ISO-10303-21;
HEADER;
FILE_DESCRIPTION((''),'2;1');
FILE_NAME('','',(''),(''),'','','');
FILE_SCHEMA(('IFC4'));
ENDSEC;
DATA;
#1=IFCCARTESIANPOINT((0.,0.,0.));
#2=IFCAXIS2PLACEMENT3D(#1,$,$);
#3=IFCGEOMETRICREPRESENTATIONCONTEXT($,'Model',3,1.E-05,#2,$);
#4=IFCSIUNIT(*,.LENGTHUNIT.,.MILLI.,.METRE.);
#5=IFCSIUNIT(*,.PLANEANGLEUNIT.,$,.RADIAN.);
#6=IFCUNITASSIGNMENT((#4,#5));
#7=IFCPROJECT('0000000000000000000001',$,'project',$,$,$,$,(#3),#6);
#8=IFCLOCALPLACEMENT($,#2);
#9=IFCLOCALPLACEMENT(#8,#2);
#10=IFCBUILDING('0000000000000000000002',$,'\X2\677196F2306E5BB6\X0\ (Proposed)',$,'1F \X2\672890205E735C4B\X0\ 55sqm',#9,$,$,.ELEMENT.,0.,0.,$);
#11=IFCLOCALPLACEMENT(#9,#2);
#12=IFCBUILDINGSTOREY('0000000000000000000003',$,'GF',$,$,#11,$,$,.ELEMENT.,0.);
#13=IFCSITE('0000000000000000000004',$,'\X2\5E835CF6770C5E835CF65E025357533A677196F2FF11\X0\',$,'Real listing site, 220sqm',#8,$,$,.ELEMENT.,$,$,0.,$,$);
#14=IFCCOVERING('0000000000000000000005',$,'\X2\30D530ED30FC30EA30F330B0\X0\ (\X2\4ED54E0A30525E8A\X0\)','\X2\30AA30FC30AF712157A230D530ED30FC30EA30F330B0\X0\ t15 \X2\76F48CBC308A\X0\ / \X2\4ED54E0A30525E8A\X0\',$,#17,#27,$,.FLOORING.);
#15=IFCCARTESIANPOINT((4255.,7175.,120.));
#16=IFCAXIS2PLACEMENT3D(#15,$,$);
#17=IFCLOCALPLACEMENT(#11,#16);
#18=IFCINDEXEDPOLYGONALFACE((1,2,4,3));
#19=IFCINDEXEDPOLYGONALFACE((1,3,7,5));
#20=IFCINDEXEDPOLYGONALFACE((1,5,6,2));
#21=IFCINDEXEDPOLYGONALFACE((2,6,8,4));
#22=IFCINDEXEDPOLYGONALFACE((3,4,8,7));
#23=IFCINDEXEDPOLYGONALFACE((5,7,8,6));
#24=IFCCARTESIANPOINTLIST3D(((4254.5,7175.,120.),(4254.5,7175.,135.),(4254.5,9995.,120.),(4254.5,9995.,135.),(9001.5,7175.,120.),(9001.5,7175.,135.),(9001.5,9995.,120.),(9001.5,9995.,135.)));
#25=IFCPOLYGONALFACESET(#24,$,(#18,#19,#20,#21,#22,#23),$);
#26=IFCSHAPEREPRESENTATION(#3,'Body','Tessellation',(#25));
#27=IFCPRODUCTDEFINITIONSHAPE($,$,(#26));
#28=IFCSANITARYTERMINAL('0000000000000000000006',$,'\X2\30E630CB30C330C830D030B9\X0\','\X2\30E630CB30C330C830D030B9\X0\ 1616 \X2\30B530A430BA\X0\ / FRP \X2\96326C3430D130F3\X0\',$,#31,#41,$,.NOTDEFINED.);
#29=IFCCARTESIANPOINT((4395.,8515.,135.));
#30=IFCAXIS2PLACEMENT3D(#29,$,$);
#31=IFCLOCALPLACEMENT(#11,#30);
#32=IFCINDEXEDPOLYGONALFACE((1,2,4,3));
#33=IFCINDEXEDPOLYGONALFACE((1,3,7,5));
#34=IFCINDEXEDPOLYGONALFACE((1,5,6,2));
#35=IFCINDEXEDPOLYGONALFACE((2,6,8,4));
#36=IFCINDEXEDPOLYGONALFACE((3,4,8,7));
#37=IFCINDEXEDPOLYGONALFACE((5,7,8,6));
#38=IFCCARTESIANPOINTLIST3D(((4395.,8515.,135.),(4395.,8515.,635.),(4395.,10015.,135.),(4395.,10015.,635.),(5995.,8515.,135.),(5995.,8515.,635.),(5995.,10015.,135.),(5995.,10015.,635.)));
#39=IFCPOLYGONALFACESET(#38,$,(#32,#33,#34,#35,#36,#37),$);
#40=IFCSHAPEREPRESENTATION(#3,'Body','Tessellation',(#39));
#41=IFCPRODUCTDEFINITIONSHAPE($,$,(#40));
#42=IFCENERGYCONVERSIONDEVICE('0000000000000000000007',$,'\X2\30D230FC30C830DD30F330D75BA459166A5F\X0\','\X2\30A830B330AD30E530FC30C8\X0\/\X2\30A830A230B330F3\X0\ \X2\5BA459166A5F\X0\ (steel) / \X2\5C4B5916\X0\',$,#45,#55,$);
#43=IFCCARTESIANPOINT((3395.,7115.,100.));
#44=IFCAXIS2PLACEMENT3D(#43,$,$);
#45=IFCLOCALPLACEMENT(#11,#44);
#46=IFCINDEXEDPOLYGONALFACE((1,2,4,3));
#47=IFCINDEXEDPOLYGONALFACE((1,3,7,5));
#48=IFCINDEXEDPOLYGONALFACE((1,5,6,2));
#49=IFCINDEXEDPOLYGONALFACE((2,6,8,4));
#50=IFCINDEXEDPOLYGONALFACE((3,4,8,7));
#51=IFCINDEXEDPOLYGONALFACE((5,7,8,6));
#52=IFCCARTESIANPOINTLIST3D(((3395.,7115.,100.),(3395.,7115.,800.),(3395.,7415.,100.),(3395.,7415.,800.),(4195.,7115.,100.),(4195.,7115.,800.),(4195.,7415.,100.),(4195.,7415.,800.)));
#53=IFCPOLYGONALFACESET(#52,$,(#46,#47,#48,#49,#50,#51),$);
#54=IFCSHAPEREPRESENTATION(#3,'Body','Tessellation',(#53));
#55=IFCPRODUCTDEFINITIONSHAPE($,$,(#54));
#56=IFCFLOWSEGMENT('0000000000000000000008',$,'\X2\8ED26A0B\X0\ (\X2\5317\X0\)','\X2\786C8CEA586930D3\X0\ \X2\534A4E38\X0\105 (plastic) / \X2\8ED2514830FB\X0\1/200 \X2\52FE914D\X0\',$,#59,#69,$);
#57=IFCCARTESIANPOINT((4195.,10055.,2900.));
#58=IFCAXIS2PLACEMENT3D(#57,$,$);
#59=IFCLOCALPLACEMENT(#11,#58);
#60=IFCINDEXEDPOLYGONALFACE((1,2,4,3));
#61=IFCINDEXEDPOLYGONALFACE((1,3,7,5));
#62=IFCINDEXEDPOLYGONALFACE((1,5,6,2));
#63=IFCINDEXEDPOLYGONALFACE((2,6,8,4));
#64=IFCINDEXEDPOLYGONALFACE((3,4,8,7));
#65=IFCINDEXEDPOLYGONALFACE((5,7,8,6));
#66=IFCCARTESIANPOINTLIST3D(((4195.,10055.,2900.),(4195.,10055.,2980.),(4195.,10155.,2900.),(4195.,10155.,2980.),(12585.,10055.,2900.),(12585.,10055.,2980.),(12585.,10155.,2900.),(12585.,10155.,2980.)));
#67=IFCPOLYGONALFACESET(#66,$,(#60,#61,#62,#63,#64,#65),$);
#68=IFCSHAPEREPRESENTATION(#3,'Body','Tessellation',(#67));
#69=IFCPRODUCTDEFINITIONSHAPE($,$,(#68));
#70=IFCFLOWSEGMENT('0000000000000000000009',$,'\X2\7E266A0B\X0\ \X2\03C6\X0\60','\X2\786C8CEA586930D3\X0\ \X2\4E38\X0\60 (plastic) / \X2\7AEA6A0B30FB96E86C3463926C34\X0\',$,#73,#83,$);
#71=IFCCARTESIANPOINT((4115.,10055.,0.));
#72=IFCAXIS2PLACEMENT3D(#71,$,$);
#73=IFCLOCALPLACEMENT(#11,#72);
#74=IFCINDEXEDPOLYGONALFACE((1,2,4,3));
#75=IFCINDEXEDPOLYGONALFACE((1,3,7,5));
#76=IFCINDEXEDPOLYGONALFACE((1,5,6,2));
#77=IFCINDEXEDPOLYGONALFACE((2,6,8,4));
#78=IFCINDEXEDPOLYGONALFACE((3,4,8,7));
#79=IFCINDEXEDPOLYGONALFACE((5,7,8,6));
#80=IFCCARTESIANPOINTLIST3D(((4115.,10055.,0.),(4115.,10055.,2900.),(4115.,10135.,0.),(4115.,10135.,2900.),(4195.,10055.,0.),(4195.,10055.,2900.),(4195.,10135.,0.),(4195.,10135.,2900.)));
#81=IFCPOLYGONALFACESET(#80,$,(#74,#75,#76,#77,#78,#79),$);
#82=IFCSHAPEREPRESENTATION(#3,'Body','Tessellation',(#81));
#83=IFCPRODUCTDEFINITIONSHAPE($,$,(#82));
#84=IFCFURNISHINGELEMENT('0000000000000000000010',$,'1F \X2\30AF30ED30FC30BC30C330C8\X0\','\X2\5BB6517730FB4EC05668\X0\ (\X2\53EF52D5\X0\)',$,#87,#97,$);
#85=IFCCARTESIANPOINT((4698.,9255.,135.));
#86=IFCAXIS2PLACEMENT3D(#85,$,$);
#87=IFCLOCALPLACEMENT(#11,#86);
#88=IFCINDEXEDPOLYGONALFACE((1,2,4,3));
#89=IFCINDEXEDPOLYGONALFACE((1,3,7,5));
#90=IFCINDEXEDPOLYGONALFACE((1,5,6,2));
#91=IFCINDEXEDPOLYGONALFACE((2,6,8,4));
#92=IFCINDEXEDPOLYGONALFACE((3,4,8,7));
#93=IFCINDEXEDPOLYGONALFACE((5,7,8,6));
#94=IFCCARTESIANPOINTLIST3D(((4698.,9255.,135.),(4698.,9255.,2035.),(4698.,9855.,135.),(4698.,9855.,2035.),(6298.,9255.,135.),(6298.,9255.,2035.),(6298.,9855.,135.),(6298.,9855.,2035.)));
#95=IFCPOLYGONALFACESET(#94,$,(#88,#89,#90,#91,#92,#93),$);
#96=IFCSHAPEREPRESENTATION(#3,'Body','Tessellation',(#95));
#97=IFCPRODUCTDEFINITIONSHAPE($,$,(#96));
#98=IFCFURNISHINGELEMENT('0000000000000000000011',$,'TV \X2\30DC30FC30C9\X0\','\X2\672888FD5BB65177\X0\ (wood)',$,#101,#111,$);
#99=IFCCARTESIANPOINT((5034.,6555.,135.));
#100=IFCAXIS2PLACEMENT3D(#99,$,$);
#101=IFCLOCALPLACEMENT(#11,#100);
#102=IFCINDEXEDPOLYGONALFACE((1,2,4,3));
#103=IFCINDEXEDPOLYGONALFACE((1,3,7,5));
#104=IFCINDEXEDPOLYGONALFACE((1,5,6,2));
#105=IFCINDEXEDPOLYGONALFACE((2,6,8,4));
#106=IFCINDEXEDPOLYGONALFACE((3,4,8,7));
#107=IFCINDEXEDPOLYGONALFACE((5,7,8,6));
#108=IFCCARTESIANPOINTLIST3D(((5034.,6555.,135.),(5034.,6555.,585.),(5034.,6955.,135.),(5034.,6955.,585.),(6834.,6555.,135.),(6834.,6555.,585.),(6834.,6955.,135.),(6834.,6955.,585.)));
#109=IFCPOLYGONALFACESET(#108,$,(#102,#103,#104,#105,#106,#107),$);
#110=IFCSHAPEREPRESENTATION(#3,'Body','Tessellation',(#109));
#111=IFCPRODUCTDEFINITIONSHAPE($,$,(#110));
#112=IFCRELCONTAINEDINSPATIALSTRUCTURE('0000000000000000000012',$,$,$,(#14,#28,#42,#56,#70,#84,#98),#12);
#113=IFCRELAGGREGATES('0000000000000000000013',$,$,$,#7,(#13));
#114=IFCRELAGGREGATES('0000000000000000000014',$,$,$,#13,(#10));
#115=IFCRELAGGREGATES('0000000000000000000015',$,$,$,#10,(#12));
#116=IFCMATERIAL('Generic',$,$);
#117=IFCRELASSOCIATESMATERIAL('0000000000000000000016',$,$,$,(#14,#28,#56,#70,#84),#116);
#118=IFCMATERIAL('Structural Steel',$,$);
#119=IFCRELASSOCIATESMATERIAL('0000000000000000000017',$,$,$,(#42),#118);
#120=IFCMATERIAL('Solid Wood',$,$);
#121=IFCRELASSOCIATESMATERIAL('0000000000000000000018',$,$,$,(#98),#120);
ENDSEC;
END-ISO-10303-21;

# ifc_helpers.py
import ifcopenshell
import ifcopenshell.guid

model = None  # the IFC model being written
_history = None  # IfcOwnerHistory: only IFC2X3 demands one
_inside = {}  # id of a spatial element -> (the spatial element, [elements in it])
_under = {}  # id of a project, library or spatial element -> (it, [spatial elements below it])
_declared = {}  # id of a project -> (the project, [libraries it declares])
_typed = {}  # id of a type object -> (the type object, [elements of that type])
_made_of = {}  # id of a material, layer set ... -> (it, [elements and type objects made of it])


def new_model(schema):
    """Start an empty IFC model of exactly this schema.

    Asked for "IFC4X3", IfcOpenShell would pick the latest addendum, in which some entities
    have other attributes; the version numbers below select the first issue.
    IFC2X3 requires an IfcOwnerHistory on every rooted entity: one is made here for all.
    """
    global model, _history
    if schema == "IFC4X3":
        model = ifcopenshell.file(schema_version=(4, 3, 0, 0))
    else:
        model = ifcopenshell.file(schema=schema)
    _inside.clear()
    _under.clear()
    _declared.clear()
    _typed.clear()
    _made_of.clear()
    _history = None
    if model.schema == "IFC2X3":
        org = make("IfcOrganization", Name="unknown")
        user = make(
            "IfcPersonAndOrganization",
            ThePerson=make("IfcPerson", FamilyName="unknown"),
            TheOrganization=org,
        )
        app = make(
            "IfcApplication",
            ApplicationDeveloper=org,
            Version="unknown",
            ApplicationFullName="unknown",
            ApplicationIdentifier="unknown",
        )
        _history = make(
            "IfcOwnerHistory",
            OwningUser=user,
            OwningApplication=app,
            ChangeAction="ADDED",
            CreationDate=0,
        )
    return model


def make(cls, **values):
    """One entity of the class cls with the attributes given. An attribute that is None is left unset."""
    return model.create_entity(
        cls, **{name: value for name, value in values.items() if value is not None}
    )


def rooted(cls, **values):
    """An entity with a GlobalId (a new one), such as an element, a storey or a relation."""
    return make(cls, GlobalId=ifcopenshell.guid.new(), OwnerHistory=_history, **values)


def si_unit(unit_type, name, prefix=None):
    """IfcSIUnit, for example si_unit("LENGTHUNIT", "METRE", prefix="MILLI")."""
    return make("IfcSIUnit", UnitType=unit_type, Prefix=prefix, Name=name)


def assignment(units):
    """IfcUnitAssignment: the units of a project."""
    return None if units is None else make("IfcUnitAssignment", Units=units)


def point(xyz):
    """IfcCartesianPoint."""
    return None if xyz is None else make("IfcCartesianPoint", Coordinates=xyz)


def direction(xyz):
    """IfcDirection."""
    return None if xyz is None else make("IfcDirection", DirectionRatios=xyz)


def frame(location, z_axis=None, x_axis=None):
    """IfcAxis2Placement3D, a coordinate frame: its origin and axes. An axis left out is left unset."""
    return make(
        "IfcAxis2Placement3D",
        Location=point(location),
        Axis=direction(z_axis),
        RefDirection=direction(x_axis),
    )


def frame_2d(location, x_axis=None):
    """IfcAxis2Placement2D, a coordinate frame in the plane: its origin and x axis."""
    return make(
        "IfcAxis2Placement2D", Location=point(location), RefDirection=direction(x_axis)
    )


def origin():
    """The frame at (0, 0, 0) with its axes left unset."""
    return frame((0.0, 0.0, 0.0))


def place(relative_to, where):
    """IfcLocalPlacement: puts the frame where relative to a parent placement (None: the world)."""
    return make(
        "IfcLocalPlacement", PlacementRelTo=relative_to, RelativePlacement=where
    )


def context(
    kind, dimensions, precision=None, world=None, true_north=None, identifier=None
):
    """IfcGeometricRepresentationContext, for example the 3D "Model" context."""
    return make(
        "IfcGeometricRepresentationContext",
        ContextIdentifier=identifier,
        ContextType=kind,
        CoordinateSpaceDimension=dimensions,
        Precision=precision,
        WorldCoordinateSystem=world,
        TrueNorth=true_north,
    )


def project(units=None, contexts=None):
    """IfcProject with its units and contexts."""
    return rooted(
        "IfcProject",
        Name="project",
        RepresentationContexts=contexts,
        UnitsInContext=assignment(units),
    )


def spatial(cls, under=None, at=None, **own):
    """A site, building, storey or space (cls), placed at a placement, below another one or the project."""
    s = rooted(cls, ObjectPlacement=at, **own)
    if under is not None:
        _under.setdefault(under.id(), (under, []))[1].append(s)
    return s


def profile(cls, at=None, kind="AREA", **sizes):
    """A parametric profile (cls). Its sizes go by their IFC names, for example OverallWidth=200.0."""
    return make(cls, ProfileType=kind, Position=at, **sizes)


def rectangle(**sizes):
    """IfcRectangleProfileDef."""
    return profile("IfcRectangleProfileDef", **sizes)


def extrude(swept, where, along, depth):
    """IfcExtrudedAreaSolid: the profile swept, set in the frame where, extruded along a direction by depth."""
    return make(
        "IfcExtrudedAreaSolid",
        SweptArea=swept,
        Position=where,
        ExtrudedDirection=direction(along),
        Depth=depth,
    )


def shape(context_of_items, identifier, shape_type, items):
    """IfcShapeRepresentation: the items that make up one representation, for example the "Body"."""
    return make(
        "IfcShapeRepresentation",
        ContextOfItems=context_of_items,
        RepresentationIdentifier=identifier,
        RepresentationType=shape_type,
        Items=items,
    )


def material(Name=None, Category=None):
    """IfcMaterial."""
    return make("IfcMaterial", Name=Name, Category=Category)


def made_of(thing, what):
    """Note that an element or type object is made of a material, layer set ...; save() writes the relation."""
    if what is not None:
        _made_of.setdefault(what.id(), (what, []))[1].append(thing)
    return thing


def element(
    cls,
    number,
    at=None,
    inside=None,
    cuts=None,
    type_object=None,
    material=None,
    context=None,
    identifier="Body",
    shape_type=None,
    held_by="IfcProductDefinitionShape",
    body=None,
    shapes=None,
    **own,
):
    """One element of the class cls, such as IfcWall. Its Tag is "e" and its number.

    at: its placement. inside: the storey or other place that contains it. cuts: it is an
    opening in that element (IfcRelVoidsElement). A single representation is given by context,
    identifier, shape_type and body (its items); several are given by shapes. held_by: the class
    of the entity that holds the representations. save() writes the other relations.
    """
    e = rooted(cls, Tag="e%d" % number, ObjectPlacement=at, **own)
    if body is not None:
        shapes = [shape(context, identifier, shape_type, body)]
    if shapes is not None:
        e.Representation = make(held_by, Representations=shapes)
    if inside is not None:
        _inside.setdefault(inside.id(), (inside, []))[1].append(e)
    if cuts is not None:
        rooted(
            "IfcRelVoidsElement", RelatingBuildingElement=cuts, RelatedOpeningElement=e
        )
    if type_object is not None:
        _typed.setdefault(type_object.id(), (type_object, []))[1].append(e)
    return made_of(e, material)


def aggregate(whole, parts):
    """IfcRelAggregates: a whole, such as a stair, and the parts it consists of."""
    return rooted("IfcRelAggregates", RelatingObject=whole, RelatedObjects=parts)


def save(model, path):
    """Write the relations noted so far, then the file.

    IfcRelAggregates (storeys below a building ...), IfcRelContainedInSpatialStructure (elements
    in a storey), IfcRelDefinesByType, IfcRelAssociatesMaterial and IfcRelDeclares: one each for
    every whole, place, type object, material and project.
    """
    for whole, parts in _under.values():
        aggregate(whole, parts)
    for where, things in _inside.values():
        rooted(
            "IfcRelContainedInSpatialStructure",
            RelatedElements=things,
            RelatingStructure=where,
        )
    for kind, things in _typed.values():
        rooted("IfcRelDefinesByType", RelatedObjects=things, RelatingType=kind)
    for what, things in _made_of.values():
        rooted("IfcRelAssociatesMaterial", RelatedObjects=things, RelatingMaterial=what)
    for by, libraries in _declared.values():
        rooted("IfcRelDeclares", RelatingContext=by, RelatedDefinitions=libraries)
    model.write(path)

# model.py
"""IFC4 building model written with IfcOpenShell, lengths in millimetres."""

from ifc_helpers import new_model, si_unit, frame, frame_2d, origin, place, context, project, spatial, rectangle, extrude, material, element, save


model = new_model("IFC4")

# Units and contexts
model_context = context("Model", 3, precision=1e-05, world=origin())
ifc_project = project(units=[si_unit("LENGTHUNIT", "METRE", prefix="MILLI"), si_unit("PLANEANGLEUNIT", "RADIAN")], contexts=[model_context])

# Site, building, storey
site_placement = place(None, origin())
site = spatial("IfcSite", under=ifc_project, at=site_placement, Name="広島県広島市南区東雲１", ObjectType="Real listing site, 220sqm", CompositionType="ELEMENT", RefElevation=0.0)
building_placement = place(site_placement, origin())
building = spatial("IfcBuilding", under=site, at=building_placement, Name="東雲の家 (Proposed)", ObjectType="1F 木造平屋 55sqm", CompositionType="ELEMENT", ElevationOfRefHeight=0.0, ElevationOfTerrain=0.0)
storey_placement = place(building_placement, origin())
storey = spatial("IfcBuildingStorey", under=building, at=storey_placement, Name="GF", CompositionType="ELEMENT", Elevation=0.0)

# Shared definitions
ifc_material_1 = material(Name="Solid Wood")

# Shared definitions
ifc_material_2 = material(Name="Structural Steel")

# Covering
ifc_material_3 = material(Name="Generic")
covering_placement = place(storey_placement, frame((4255.0, 7175.0, 120.0)))
element("IfcCovering", 1, at=covering_placement, inside=storey, material=ifc_material_3, Name="フローリング (仕上げ床)", Description="オーク無垢フローリング t15 直貼り / 仕上げ床", PredefinedType="FLOORING", context=model_context, shape_type="SweptSolid", body=[
    extrude(rectangle(XDim=4747.0, YDim=2820.0, at=frame_2d((2373.0, 1410.0))), frame((4255.0, 7175.0, 120.0)), (0.0, 0.0, 1.0), 15.0),
])

# Sanitary terminal
sanitary_terminal_placement = place(storey_placement, frame((4395.0, 8515.0, 135.0)))
element("IfcSanitaryTerminal", 2, at=sanitary_terminal_placement, inside=storey, material=ifc_material_3, Name="ユニットバス", Description="ユニットバス 1616 サイズ / FRP 防水パン", PredefinedType="NOTDEFINED", context=model_context, shape_type="SweptSolid", body=[
    extrude(rectangle(XDim=1600.0, YDim=1500.0, at=frame_2d((800.0, 750.0))), frame((4395.0, 8515.0, 135.0)), (0.0, 0.0, 1.0), 500.0),
])

# Energy conversion device
energy_conversion_device_placement = place(storey_placement, frame((3395.0, 7115.0, 100.0)))
element("IfcEnergyConversionDevice", 3, at=energy_conversion_device_placement, inside=storey, material=ifc_material_2, Name="ヒートポンプ室外機", Description="エコキュート/エアコン 室外機 (steel) / 屋外", context=model_context, shape_type="SweptSolid", body=[
    extrude(rectangle(XDim=800.0, YDim=300.0, at=frame_2d((400.0, 150.0))), frame((3395.0, 7115.0, 100.0)), (0.0, 0.0, 1.0), 700.0),
])

# Flow segments
flow_segment_1_placement = place(storey_placement, frame((4195.0, 10055.0, 2900.0)))
element("IfcFlowSegment", 4, at=flow_segment_1_placement, inside=storey, material=ifc_material_3, Name="軒樋 (北)", Description="硬質塩ビ 半丸105 (plastic) / 軒先・1/200 勾配", context=model_context, shape_type="SweptSolid", body=[
    extrude(rectangle(XDim=8390.0, YDim=100.0, at=frame_2d((4195.0, 50.0))), frame((4195.0, 10055.0, 2900.0)), (0.0, 0.0, 1.0), 80.0),
])
flow_segment_2_placement = place(storey_placement, frame((4115.0, 10055.0, 0.0)))
element("IfcFlowSegment", 5, at=flow_segment_2_placement, inside=storey, material=ifc_material_3, Name="縦樋 φ60", Description="硬質塩ビ 丸60 (plastic) / 竪樋・雨水排水", context=model_context, shape_type="SweptSolid", body=[
    extrude(rectangle(XDim=80.0, YDim=80.0, at=frame_2d((40.0, 40.0))), frame((4115.0, 10055.0, 0.0)), (0.0, 0.0, 1.0), 2900.0),
])

# Furnishing elements
furnishing_1_placement = place(storey_placement, frame((4698.0, 9255.0, 135.0)))
element("IfcFurnishingElement", 6, at=furnishing_1_placement, inside=storey, material=ifc_material_3, Name="1F クローゼット", Description="家具・什器 (可動)", context=model_context, shape_type="SweptSolid", body=[
    extrude(rectangle(XDim=1600.0, YDim=600.0, at=frame_2d((800.0, 300.0))), frame((4698.0, 9255.0, 135.0)), (0.0, 0.0, 1.0), 1900.0),
])
furnishing_2_placement = place(storey_placement, frame((5034.0, 6555.0, 135.0)))
element("IfcFurnishingElement", 7, at=furnishing_2_placement, inside=storey, material=ifc_material_1, Name="TV ボード", Description="木製家具 (wood)", context=model_context, shape_type="SweptSolid", body=[
    extrude(rectangle(XDim=1800.0, YDim=400.0, at=frame_2d((900.0, 200.0))), frame((5034.0, 6555.0, 135.0)), (0.0, 0.0, 1.0), 450.0),
])

save(model, "model.ifc")
